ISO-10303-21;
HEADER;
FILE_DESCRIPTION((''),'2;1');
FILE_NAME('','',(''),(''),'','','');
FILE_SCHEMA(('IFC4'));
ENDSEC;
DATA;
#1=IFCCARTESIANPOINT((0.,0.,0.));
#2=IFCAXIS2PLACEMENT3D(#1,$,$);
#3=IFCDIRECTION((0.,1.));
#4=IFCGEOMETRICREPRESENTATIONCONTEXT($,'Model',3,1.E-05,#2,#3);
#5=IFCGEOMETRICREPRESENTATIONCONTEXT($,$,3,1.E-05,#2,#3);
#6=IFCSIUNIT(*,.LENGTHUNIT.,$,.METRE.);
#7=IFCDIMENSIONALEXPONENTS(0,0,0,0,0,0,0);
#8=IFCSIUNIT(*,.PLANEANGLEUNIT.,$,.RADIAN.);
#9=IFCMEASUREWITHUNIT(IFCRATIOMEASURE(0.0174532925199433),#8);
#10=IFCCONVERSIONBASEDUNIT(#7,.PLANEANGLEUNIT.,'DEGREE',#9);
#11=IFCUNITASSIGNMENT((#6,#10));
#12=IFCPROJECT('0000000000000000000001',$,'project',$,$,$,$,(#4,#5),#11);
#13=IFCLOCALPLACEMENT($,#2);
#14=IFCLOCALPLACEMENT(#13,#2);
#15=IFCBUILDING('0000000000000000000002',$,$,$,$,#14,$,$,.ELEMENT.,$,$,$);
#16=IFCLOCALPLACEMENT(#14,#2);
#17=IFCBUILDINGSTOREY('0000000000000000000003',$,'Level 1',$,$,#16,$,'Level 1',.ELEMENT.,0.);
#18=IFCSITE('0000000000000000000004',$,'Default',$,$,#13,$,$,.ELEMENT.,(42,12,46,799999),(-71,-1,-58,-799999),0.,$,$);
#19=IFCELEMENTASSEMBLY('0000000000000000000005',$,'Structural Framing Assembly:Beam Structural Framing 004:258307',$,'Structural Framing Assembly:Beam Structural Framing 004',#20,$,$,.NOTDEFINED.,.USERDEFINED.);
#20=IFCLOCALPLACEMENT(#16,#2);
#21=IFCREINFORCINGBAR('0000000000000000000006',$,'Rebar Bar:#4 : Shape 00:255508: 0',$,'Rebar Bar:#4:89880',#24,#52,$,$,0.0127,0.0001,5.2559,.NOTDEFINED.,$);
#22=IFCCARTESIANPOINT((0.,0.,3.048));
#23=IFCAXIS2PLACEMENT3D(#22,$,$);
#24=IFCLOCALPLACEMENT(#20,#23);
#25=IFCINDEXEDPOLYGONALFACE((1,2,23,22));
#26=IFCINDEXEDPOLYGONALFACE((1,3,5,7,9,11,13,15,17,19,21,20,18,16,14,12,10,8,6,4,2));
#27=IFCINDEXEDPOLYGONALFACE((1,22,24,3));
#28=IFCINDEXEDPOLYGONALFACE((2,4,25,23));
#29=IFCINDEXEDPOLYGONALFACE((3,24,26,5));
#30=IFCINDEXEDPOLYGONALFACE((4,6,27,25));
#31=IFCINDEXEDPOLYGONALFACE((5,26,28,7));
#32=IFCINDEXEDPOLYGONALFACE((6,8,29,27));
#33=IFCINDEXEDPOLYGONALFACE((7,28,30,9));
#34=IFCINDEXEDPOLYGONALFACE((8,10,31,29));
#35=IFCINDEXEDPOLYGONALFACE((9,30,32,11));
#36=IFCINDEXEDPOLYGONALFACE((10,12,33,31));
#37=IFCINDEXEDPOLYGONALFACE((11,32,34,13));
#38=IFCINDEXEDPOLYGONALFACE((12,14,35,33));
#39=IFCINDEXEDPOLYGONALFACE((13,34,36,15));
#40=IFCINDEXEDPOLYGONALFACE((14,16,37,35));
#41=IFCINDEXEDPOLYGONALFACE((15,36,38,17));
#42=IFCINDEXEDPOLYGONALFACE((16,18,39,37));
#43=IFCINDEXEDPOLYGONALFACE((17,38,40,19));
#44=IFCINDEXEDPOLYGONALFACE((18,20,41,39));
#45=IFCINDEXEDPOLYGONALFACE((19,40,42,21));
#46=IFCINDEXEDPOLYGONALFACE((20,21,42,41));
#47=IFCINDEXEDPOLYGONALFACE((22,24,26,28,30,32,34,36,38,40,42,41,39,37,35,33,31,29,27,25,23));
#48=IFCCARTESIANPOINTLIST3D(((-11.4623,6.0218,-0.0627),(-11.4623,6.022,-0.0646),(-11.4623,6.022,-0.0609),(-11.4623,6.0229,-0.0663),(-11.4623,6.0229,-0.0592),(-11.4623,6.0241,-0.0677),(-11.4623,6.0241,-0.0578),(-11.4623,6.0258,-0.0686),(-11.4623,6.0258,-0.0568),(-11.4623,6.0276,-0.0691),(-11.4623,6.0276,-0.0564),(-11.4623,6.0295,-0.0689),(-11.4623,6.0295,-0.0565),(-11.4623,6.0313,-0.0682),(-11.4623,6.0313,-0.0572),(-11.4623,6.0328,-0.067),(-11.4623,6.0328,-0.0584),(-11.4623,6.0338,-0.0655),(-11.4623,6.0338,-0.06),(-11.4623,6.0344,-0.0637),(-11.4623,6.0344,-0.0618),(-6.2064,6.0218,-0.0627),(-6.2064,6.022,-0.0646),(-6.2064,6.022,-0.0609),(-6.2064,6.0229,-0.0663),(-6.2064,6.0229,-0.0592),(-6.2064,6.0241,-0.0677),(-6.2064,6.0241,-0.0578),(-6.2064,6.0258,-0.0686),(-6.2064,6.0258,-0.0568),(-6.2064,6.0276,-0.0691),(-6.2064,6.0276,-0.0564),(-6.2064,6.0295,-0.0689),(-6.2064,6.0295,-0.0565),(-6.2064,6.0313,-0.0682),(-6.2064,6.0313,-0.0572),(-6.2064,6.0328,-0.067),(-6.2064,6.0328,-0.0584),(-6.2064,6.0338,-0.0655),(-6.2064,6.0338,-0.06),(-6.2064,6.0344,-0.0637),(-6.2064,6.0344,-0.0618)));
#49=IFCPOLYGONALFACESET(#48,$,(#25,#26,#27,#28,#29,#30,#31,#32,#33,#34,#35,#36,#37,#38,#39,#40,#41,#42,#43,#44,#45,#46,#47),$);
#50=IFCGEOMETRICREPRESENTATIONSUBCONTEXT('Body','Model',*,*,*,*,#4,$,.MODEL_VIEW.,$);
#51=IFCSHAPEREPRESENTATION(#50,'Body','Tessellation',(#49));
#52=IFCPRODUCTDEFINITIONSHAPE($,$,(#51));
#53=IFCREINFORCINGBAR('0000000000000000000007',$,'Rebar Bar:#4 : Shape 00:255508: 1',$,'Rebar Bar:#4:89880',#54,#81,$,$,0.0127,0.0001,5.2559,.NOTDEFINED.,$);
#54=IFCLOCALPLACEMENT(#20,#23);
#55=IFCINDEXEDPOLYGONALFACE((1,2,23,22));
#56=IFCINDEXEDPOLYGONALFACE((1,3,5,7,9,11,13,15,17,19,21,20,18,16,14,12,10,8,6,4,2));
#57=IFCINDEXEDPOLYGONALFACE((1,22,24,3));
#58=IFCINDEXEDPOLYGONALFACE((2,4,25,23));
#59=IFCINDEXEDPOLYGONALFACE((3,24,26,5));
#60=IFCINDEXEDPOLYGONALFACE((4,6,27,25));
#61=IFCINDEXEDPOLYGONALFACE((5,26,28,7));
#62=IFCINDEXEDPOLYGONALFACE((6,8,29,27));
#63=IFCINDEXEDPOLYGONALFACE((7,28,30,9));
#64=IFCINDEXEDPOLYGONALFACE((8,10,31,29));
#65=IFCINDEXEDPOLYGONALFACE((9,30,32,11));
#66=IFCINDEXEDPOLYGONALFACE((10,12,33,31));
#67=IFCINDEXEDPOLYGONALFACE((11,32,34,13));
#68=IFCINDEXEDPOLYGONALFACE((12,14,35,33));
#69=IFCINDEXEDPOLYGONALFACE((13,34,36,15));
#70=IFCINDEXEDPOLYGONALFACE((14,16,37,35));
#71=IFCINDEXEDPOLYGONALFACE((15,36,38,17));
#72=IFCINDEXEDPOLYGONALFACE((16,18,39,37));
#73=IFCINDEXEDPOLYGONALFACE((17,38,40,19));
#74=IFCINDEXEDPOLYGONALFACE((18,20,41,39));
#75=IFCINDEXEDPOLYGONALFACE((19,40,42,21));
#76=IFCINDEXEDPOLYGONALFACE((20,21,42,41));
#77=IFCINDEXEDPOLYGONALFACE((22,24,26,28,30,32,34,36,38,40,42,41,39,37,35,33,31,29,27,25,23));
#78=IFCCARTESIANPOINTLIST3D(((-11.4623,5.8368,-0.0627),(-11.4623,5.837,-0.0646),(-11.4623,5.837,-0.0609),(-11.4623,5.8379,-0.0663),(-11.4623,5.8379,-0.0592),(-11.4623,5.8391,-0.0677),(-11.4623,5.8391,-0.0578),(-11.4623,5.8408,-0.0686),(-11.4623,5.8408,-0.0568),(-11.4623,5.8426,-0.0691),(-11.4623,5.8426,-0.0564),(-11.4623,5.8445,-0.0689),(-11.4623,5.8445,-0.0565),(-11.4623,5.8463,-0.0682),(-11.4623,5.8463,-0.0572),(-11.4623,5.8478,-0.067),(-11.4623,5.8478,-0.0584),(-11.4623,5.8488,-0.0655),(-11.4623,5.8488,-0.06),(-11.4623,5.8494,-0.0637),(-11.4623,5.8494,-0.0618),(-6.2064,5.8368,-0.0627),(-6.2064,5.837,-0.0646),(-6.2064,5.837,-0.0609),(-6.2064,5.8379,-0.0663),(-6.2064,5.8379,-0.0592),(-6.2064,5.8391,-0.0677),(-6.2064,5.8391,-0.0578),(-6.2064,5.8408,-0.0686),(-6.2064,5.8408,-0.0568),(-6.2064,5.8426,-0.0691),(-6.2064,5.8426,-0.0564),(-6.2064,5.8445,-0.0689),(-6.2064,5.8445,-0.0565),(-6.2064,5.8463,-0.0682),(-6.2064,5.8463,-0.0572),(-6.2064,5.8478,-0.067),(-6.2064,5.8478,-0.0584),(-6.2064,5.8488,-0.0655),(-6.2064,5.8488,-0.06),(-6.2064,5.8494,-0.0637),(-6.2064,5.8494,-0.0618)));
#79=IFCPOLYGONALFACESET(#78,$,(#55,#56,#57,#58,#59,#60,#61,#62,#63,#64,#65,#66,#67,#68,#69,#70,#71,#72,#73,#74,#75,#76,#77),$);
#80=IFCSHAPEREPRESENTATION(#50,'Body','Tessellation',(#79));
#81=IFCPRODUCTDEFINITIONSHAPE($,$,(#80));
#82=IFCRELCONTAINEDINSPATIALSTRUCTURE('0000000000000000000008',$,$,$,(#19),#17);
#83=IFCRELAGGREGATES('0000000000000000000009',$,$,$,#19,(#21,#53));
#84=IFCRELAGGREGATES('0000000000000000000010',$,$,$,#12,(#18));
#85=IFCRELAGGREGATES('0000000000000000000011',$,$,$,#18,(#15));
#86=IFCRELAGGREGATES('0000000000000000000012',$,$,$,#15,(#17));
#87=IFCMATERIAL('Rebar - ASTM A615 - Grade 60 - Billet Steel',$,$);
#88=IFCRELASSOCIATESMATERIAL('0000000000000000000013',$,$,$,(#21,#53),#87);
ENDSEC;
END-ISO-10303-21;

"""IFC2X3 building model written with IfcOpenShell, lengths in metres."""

from ifc_helpers import new_model, entity, si_unit, converted_unit, direction, frame, origin, place, context, subcontext, project, spatial, material, element, aggregate, save


model = new_model("IFC2X3")

# Units and contexts
model_context = context("Model", 3, precision=1e-05, world=origin(), true_north=direction((0.0, 1.0)))
context_of_model = context(None, 3, precision=1e-05, world=origin(), true_north=direction((0.0, 1.0)))
body_context = subcontext(model_context, "Body", "Model", "MODEL_VIEW")
ifc_project = project(units=[si_unit("LENGTHUNIT", "METRE"), converted_unit("PLANEANGLEUNIT", "DEGREE", entity("IfcRatioMeasure", 0.0174532925199433), si_unit("PLANEANGLEUNIT", "RADIAN"), dimensions=[0, 0, 0, 0, 0, 0, 0])], contexts=[model_context, context_of_model])

# Site, building, storey
site_placement = place(None, origin())
site = spatial("IfcSite", under=ifc_project, at=site_placement, Name="Default", CompositionType="ELEMENT", RefLatitude=(42, 12, 46, 799999), RefLongitude=(-71, -1, -58, -799999), RefElevation=0.0)
building_placement = place(site_placement, origin())
building = spatial("IfcBuilding", under=site, at=building_placement, CompositionType="ELEMENT")
storey_placement = place(building_placement, origin())
storey = spatial("IfcBuildingStorey", under=building, at=storey_placement, Name="Level 1", LongName="Level 1", CompositionType="ELEMENT", Elevation=0.0)

# Element assembly, reinforcing bars
assembly_placement = place(storey_placement, origin())
assembly = element("IfcElementAssembly", 1, at=assembly_placement, inside=storey, Name="Structural Framing Assembly:Beam Structural Framing 004:258307", ObjectType="Structural Framing Assembly:Beam Structural Framing 004", AssemblyPlace="NOTDEFINED", PredefinedType="USERDEFINED")
ifc_material_1 = material(Name="Rebar - ASTM A615 - Grade 60 - Billet Steel")
reinforcing_bar_1_placement = place(assembly_placement, frame((0.0, 0.0, 3.048)))
reinforcing_bar_1 = element("IfcReinforcingBar", 2, at=reinforcing_bar_1_placement, material=ifc_material_1, Name="Rebar Bar:#4 : Shape 00:255508: 0", ObjectType="Rebar Bar:#4:89880", BarLength=5.2559, BarRole="NOTDEFINED", CrossSectionArea=0.0001, NominalDiameter=0.0127, context=body_context, shape_type="AdvancedSweptSolid", body=[
    entity("IfcSweptDiskSolid", entity("IfcCompositeCurve", [entity("IfcCompositeCurveSegment", "CONTINUOUS", True, entity("IfcPolyline", [entity("IfcCartesianPoint", [-6.2064, 6.0281, -0.0627]), entity("IfcCartesianPoint", [-11.4623, 6.0281, -0.0627])]))], False), 0.0063, None, 0.0, 1.0),
])
reinforcing_bar_2_placement = place(assembly_placement, frame((0.0, 0.0, 3.048)))
reinforcing_bar_2 = element("IfcReinforcingBar", 3, at=reinforcing_bar_2_placement, material=ifc_material_1, Name="Rebar Bar:#4 : Shape 00:255508: 1", ObjectType="Rebar Bar:#4:89880", BarLength=5.2559, BarRole="NOTDEFINED", CrossSectionArea=0.0001, NominalDiameter=0.0127, context=body_context, shape_type="AdvancedSweptSolid", body=[
    entity("IfcSweptDiskSolid", entity("IfcCompositeCurve", [entity("IfcCompositeCurveSegment", "CONTINUOUS", True, entity("IfcPolyline", [entity("IfcCartesianPoint", [-6.2064, 5.8431, -0.0627]), entity("IfcCartesianPoint", [-11.4623, 5.8431, -0.0627])]))], False), 0.0063, None, 0.0, 1.0),
])
aggregate(assembly, [reinforcing_bar_1, reinforcing_bar_2])

save(model, "model.ifc")
